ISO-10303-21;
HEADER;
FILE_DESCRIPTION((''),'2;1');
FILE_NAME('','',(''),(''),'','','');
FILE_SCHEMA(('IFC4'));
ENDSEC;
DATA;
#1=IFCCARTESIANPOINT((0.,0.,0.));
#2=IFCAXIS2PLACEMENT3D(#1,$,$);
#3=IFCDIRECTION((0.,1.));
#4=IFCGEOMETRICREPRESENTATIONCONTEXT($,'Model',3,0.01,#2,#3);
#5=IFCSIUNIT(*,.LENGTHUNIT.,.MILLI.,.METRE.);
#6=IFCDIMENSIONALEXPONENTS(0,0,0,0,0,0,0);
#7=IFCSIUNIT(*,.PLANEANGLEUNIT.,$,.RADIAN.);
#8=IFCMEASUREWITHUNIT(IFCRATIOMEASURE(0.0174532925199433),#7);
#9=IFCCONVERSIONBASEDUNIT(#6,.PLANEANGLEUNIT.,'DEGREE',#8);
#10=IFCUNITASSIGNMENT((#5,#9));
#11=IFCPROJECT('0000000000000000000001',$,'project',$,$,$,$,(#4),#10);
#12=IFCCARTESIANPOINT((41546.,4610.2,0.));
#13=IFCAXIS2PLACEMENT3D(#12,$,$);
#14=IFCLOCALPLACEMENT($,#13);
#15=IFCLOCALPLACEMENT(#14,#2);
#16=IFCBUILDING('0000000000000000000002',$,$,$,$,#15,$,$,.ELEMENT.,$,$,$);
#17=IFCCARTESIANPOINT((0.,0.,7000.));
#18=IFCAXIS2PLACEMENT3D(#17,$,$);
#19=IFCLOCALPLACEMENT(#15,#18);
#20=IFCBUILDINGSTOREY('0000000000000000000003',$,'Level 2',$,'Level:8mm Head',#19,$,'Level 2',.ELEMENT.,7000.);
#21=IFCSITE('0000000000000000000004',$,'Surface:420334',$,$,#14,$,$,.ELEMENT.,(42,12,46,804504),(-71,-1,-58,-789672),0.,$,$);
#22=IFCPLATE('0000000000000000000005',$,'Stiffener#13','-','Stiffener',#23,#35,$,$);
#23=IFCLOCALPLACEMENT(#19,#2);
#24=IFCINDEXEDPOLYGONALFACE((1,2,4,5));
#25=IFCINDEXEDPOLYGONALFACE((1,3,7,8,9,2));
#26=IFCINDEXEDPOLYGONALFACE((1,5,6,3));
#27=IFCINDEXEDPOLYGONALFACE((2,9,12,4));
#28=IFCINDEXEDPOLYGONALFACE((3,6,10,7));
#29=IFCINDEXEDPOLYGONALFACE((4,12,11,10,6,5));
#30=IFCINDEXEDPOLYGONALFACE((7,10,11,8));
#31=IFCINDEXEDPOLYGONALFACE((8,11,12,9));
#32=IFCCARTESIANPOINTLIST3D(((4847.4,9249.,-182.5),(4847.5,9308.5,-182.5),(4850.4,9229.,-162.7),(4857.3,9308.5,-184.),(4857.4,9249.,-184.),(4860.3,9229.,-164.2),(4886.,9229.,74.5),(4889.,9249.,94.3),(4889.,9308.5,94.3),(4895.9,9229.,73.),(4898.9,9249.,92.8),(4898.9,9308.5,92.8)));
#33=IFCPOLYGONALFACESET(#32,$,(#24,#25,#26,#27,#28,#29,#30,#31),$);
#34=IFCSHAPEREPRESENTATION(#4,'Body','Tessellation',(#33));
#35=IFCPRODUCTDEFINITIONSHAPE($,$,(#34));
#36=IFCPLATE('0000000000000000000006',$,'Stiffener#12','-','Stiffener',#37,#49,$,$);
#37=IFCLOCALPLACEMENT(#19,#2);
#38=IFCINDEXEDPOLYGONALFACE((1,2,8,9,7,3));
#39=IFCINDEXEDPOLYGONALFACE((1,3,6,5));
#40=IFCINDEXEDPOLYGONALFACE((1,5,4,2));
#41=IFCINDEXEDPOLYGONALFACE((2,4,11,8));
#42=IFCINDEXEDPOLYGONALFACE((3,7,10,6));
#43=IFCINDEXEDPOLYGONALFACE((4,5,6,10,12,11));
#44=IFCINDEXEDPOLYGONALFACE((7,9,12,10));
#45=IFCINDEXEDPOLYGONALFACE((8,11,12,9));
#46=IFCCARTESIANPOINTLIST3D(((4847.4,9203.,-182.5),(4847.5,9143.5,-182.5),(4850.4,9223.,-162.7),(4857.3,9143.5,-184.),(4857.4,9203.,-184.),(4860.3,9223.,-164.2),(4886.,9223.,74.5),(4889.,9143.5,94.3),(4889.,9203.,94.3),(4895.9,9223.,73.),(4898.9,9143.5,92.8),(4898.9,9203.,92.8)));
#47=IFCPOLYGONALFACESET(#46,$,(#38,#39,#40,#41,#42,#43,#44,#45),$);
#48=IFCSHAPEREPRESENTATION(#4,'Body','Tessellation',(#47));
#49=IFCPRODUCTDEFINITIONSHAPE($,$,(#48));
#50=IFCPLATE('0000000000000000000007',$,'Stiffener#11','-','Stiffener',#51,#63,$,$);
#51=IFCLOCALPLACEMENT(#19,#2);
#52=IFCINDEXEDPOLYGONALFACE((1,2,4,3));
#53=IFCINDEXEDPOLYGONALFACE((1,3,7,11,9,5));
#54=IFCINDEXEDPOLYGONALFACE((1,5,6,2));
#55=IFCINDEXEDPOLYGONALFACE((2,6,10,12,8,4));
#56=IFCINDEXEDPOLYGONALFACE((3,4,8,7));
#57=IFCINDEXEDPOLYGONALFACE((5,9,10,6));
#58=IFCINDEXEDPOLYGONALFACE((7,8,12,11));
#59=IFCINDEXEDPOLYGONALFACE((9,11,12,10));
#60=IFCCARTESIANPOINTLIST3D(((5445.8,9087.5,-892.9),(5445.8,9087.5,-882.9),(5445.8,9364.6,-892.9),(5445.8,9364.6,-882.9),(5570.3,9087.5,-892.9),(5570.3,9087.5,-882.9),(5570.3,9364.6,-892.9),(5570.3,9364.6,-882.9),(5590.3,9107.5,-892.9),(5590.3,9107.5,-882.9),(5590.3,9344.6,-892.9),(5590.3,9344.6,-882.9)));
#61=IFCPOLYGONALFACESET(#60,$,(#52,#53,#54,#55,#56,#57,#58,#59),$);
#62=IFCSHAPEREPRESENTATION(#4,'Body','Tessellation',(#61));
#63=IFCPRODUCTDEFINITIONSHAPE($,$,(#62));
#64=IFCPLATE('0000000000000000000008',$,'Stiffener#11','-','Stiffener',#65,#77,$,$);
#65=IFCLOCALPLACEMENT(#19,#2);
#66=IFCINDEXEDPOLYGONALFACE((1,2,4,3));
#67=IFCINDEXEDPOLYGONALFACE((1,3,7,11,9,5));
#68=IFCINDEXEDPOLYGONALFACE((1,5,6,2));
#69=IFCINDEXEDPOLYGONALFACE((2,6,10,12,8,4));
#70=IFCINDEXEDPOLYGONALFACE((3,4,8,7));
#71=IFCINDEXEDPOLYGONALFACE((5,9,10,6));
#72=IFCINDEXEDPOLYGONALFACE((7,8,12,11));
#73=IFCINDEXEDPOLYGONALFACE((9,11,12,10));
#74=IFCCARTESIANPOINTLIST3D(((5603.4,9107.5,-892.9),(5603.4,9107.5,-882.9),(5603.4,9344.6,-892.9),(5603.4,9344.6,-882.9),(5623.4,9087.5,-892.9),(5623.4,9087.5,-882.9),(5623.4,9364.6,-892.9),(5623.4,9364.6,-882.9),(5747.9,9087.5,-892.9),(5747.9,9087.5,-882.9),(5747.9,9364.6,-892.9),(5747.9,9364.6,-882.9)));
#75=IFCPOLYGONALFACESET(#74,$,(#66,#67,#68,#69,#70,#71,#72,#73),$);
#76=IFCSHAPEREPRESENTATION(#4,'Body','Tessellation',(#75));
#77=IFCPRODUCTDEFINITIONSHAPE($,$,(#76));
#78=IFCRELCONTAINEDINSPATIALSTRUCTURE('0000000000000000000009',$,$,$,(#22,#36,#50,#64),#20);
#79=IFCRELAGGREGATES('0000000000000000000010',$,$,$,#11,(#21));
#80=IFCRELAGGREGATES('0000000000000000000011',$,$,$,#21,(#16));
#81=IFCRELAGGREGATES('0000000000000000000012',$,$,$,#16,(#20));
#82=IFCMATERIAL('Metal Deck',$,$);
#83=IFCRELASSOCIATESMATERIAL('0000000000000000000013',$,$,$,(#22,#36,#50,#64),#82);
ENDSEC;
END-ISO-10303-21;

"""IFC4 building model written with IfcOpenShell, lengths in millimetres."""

from ifc_helpers import new_model, entity, si_unit, converted_unit, direction, frame, origin, origin_with_axes, place, context, project, spatial, polyline, outline, extrude, material, element, save


model = new_model("IFC4")

# Units and contexts
model_context = context("Model", 3, precision=0.01, world=origin(), true_north=direction((0.0, 1.0)))
ifc_project = project(units=[si_unit("LENGTHUNIT", "METRE", prefix="MILLI"), converted_unit("PLANEANGLEUNIT", "DEGREE", entity("IfcRatioMeasure", 0.0174532925199433), si_unit("PLANEANGLEUNIT", "RADIAN"), dimensions=[0, 0, 0, 0, 0, 0, 0])], contexts=[model_context])

# Site, building, storey
site_placement = place(None, frame((41546.0, 4610.2, 0.0)))
site = spatial("IfcSite", under=ifc_project, at=site_placement, Name="Surface:420334", CompositionType="ELEMENT", RefLatitude=(42, 12, 46, 804504), RefLongitude=(-71, -1, -58, -789672), RefElevation=0.0)
building_placement = place(site_placement, origin())
building = spatial("IfcBuilding", under=site, at=building_placement, CompositionType="ELEMENT")
storey_placement = place(building_placement, frame((0.0, 0.0, 7000.0)))
storey = spatial("IfcBuildingStorey", under=building, at=storey_placement, Name="Level 2", ObjectType="Level:8mm Head", LongName="Level 2", CompositionType="ELEMENT", Elevation=7000.0)

# Plates, openings
ifc_material = material(Name="Metal Deck")
plate_1_placement = place(storey_placement, frame((4857.3, 9308.5, -184.0), z_axis=(-0.988936, 0.0, 0.14834), x_axis=(0.0, -1.0, 0.0)))
plate_1 = element("IfcPlate", 1, at=plate_1_placement, inside=storey, material=ifc_material, Name="Stiffener#13", Description="-", ObjectType="Stiffener", context=model_context, shape_type="SweptSolid", body=[
    extrude(outline(polyline([(0.0, 0.0), (79.5, 0.0), (79.5, 279.8), (0.0, 279.8), (0.0, 0.0)])), origin_with_axes(), (0.0, 0.0, 1.0), 10.0),
])
opening_1_placement = place(plate_1_placement, frame((0.0, 0.0, 0.0), z_axis=(0.0, 0.0, 1.0), x_axis=(1.0, 0.0, 0.0)))
element("IfcOpeningElement", 2, at=opening_1_placement, cuts=plate_1, ObjectType="Opening", context=model_context, shape_type="SweptSolid", body=[
    extrude(outline(polyline([(79.5, 279.8), (59.5, 279.8), (79.5, 259.8), (79.5, 279.8)])), origin(), (0.0, 0.0, 1.0), 10.0),
])
opening_2_placement = place(plate_1_placement, frame((0.0, 0.0, 0.0), z_axis=(0.0, 0.0, 1.0), x_axis=(1.0, 0.0, 0.0)))
element("IfcOpeningElement", 3, at=opening_2_placement, cuts=plate_1, ObjectType="Opening", context=model_context, shape_type="SweptSolid", body=[
    extrude(outline(polyline([(79.5, 0.0), (79.5, 20.0), (59.5, 0.0), (79.5, 0.0)])), origin(), (0.0, 0.0, 1.0), 10.0),
])
plate_2_placement = place(storey_placement, frame((4857.3, 9223.0, -184.0), z_axis=(-0.988936, 0.0, 0.14834), x_axis=(0.0, -1.0, 0.0)))
plate_2 = element("IfcPlate", 4, at=plate_2_placement, inside=storey, material=ifc_material, Name="Stiffener#12", Description="-", ObjectType="Stiffener", context=model_context, shape_type="SweptSolid", body=[
    extrude(outline(polyline([(0.0, 0.0), (79.5, 0.0), (79.5, 279.8), (0.0, 279.8), (0.0, 0.0)])), origin_with_axes(), (0.0, 0.0, 1.0), 10.0),
])
opening_3_placement = place(plate_2_placement, frame((0.0, 0.0, 0.0), z_axis=(0.0, 0.0, 1.0), x_axis=(1.0, 0.0, 0.0)))
element("IfcOpeningElement", 5, at=opening_3_placement, cuts=plate_2, ObjectType="Opening", context=model_context, shape_type="SweptSolid", body=[
    extrude(outline(polyline([(0.0, 279.8), (0.0, 259.8), (20.0, 279.8), (0.0, 279.8)])), origin(), (0.0, 0.0, 1.0), 10.0),
])
opening_4_placement = place(plate_2_placement, frame((0.0, 0.0, 0.0), z_axis=(0.0, 0.0, 1.0), x_axis=(1.0, 0.0, 0.0)))
element("IfcOpeningElement", 6, at=opening_4_placement, cuts=plate_2, ObjectType="Opening", context=model_context, shape_type="SweptSolid", body=[
    extrude(outline(polyline([(0.0, 0.0), (20.0, 0.0), (0.0, 20.0), (0.0, 0.0)])), origin(), (0.0, 0.0, 1.0), 10.0),
])
plate_3_placement = place(storey_placement, frame((5445.8, 9087.5, -882.9), z_axis=(0.0, 0.0, -1.0), x_axis=(0.0, 1.0, 0.0)))
plate_3 = element("IfcPlate", 7, at=plate_3_placement, inside=storey, material=ifc_material, Name="Stiffener#11", Description="-", ObjectType="Stiffener", context=model_context, shape_type="SweptSolid", body=[
    extrude(outline(polyline([(0.0, 0.0), (277.1, 0.0), (277.1, 144.5), (0.0, 144.5), (0.0, 0.0)])), origin_with_axes(), (0.0, 0.0, 1.0), 10.0),
])
opening_5_placement = place(plate_3_placement, frame((0.0, 0.0, 0.0), z_axis=(0.0, 0.0, 1.0), x_axis=(1.0, 0.0, 0.0)))
element("IfcOpeningElement", 8, at=opening_5_placement, cuts=plate_3, ObjectType="Opening", context=model_context, shape_type="SweptSolid", body=[
    extrude(outline(polyline([(277.1, 144.5), (257.1, 144.5), (277.1, 124.5), (277.1, 144.5)])), origin(), (0.0, 0.0, 1.0), 10.0),
])
opening_6_placement = place(plate_3_placement, frame((0.0, 0.0, 0.0), z_axis=(0.0, 0.0, 1.0), x_axis=(1.0, 0.0, 0.0)))
element("IfcOpeningElement", 9, at=opening_6_placement, cuts=plate_3, ObjectType="Opening", context=model_context, shape_type="SweptSolid", body=[
    extrude(outline(polyline([(0.0, 144.5), (0.0, 124.5), (20.0, 144.5), (0.0, 144.5)])), origin(), (0.0, 0.0, 1.0), 10.0),
])
plate_4_placement = place(storey_placement, frame((5603.4, 9087.5, -882.9), z_axis=(0.0, 0.0, -1.0), x_axis=(0.0, 1.0, 0.0)))
plate_4 = element("IfcPlate", 10, at=plate_4_placement, inside=storey, material=ifc_material, Name="Stiffener#11", Description="-", ObjectType="Stiffener", context=model_context, shape_type="SweptSolid", body=[
    extrude(outline(polyline([(0.0, 0.0), (277.1, 0.0), (277.1, 144.5), (0.0, 144.5), (0.0, 0.0)])), origin_with_axes(), (0.0, 0.0, 1.0), 10.0),
])
opening_7_placement = place(plate_4_placement, frame((0.0, 0.0, 0.0), z_axis=(0.0, 0.0, 1.0), x_axis=(1.0, 0.0, 0.0)))
element("IfcOpeningElement", 11, at=opening_7_placement, cuts=plate_4, ObjectType="Opening", context=model_context, shape_type="SweptSolid", body=[
    extrude(outline(polyline([(277.1, 0.0), (277.1, 20.0), (257.1, 0.0), (277.1, 0.0)])), origin(), (0.0, 0.0, 1.0), 10.0),
])
opening_8_placement = place(plate_4_placement, frame((0.0, 0.0, 0.0), z_axis=(0.0, 0.0, 1.0), x_axis=(1.0, 0.0, 0.0)))
element("IfcOpeningElement", 12, at=opening_8_placement, cuts=plate_4, ObjectType="Opening", context=model_context, shape_type="SweptSolid", body=[
    extrude(outline(polyline([(0.0, 0.0), (20.0, 0.0), (0.0, 20.0), (0.0, 0.0)])), origin(), (0.0, 0.0, 1.0), 10.0),
])

save(model, "model.ifc")
